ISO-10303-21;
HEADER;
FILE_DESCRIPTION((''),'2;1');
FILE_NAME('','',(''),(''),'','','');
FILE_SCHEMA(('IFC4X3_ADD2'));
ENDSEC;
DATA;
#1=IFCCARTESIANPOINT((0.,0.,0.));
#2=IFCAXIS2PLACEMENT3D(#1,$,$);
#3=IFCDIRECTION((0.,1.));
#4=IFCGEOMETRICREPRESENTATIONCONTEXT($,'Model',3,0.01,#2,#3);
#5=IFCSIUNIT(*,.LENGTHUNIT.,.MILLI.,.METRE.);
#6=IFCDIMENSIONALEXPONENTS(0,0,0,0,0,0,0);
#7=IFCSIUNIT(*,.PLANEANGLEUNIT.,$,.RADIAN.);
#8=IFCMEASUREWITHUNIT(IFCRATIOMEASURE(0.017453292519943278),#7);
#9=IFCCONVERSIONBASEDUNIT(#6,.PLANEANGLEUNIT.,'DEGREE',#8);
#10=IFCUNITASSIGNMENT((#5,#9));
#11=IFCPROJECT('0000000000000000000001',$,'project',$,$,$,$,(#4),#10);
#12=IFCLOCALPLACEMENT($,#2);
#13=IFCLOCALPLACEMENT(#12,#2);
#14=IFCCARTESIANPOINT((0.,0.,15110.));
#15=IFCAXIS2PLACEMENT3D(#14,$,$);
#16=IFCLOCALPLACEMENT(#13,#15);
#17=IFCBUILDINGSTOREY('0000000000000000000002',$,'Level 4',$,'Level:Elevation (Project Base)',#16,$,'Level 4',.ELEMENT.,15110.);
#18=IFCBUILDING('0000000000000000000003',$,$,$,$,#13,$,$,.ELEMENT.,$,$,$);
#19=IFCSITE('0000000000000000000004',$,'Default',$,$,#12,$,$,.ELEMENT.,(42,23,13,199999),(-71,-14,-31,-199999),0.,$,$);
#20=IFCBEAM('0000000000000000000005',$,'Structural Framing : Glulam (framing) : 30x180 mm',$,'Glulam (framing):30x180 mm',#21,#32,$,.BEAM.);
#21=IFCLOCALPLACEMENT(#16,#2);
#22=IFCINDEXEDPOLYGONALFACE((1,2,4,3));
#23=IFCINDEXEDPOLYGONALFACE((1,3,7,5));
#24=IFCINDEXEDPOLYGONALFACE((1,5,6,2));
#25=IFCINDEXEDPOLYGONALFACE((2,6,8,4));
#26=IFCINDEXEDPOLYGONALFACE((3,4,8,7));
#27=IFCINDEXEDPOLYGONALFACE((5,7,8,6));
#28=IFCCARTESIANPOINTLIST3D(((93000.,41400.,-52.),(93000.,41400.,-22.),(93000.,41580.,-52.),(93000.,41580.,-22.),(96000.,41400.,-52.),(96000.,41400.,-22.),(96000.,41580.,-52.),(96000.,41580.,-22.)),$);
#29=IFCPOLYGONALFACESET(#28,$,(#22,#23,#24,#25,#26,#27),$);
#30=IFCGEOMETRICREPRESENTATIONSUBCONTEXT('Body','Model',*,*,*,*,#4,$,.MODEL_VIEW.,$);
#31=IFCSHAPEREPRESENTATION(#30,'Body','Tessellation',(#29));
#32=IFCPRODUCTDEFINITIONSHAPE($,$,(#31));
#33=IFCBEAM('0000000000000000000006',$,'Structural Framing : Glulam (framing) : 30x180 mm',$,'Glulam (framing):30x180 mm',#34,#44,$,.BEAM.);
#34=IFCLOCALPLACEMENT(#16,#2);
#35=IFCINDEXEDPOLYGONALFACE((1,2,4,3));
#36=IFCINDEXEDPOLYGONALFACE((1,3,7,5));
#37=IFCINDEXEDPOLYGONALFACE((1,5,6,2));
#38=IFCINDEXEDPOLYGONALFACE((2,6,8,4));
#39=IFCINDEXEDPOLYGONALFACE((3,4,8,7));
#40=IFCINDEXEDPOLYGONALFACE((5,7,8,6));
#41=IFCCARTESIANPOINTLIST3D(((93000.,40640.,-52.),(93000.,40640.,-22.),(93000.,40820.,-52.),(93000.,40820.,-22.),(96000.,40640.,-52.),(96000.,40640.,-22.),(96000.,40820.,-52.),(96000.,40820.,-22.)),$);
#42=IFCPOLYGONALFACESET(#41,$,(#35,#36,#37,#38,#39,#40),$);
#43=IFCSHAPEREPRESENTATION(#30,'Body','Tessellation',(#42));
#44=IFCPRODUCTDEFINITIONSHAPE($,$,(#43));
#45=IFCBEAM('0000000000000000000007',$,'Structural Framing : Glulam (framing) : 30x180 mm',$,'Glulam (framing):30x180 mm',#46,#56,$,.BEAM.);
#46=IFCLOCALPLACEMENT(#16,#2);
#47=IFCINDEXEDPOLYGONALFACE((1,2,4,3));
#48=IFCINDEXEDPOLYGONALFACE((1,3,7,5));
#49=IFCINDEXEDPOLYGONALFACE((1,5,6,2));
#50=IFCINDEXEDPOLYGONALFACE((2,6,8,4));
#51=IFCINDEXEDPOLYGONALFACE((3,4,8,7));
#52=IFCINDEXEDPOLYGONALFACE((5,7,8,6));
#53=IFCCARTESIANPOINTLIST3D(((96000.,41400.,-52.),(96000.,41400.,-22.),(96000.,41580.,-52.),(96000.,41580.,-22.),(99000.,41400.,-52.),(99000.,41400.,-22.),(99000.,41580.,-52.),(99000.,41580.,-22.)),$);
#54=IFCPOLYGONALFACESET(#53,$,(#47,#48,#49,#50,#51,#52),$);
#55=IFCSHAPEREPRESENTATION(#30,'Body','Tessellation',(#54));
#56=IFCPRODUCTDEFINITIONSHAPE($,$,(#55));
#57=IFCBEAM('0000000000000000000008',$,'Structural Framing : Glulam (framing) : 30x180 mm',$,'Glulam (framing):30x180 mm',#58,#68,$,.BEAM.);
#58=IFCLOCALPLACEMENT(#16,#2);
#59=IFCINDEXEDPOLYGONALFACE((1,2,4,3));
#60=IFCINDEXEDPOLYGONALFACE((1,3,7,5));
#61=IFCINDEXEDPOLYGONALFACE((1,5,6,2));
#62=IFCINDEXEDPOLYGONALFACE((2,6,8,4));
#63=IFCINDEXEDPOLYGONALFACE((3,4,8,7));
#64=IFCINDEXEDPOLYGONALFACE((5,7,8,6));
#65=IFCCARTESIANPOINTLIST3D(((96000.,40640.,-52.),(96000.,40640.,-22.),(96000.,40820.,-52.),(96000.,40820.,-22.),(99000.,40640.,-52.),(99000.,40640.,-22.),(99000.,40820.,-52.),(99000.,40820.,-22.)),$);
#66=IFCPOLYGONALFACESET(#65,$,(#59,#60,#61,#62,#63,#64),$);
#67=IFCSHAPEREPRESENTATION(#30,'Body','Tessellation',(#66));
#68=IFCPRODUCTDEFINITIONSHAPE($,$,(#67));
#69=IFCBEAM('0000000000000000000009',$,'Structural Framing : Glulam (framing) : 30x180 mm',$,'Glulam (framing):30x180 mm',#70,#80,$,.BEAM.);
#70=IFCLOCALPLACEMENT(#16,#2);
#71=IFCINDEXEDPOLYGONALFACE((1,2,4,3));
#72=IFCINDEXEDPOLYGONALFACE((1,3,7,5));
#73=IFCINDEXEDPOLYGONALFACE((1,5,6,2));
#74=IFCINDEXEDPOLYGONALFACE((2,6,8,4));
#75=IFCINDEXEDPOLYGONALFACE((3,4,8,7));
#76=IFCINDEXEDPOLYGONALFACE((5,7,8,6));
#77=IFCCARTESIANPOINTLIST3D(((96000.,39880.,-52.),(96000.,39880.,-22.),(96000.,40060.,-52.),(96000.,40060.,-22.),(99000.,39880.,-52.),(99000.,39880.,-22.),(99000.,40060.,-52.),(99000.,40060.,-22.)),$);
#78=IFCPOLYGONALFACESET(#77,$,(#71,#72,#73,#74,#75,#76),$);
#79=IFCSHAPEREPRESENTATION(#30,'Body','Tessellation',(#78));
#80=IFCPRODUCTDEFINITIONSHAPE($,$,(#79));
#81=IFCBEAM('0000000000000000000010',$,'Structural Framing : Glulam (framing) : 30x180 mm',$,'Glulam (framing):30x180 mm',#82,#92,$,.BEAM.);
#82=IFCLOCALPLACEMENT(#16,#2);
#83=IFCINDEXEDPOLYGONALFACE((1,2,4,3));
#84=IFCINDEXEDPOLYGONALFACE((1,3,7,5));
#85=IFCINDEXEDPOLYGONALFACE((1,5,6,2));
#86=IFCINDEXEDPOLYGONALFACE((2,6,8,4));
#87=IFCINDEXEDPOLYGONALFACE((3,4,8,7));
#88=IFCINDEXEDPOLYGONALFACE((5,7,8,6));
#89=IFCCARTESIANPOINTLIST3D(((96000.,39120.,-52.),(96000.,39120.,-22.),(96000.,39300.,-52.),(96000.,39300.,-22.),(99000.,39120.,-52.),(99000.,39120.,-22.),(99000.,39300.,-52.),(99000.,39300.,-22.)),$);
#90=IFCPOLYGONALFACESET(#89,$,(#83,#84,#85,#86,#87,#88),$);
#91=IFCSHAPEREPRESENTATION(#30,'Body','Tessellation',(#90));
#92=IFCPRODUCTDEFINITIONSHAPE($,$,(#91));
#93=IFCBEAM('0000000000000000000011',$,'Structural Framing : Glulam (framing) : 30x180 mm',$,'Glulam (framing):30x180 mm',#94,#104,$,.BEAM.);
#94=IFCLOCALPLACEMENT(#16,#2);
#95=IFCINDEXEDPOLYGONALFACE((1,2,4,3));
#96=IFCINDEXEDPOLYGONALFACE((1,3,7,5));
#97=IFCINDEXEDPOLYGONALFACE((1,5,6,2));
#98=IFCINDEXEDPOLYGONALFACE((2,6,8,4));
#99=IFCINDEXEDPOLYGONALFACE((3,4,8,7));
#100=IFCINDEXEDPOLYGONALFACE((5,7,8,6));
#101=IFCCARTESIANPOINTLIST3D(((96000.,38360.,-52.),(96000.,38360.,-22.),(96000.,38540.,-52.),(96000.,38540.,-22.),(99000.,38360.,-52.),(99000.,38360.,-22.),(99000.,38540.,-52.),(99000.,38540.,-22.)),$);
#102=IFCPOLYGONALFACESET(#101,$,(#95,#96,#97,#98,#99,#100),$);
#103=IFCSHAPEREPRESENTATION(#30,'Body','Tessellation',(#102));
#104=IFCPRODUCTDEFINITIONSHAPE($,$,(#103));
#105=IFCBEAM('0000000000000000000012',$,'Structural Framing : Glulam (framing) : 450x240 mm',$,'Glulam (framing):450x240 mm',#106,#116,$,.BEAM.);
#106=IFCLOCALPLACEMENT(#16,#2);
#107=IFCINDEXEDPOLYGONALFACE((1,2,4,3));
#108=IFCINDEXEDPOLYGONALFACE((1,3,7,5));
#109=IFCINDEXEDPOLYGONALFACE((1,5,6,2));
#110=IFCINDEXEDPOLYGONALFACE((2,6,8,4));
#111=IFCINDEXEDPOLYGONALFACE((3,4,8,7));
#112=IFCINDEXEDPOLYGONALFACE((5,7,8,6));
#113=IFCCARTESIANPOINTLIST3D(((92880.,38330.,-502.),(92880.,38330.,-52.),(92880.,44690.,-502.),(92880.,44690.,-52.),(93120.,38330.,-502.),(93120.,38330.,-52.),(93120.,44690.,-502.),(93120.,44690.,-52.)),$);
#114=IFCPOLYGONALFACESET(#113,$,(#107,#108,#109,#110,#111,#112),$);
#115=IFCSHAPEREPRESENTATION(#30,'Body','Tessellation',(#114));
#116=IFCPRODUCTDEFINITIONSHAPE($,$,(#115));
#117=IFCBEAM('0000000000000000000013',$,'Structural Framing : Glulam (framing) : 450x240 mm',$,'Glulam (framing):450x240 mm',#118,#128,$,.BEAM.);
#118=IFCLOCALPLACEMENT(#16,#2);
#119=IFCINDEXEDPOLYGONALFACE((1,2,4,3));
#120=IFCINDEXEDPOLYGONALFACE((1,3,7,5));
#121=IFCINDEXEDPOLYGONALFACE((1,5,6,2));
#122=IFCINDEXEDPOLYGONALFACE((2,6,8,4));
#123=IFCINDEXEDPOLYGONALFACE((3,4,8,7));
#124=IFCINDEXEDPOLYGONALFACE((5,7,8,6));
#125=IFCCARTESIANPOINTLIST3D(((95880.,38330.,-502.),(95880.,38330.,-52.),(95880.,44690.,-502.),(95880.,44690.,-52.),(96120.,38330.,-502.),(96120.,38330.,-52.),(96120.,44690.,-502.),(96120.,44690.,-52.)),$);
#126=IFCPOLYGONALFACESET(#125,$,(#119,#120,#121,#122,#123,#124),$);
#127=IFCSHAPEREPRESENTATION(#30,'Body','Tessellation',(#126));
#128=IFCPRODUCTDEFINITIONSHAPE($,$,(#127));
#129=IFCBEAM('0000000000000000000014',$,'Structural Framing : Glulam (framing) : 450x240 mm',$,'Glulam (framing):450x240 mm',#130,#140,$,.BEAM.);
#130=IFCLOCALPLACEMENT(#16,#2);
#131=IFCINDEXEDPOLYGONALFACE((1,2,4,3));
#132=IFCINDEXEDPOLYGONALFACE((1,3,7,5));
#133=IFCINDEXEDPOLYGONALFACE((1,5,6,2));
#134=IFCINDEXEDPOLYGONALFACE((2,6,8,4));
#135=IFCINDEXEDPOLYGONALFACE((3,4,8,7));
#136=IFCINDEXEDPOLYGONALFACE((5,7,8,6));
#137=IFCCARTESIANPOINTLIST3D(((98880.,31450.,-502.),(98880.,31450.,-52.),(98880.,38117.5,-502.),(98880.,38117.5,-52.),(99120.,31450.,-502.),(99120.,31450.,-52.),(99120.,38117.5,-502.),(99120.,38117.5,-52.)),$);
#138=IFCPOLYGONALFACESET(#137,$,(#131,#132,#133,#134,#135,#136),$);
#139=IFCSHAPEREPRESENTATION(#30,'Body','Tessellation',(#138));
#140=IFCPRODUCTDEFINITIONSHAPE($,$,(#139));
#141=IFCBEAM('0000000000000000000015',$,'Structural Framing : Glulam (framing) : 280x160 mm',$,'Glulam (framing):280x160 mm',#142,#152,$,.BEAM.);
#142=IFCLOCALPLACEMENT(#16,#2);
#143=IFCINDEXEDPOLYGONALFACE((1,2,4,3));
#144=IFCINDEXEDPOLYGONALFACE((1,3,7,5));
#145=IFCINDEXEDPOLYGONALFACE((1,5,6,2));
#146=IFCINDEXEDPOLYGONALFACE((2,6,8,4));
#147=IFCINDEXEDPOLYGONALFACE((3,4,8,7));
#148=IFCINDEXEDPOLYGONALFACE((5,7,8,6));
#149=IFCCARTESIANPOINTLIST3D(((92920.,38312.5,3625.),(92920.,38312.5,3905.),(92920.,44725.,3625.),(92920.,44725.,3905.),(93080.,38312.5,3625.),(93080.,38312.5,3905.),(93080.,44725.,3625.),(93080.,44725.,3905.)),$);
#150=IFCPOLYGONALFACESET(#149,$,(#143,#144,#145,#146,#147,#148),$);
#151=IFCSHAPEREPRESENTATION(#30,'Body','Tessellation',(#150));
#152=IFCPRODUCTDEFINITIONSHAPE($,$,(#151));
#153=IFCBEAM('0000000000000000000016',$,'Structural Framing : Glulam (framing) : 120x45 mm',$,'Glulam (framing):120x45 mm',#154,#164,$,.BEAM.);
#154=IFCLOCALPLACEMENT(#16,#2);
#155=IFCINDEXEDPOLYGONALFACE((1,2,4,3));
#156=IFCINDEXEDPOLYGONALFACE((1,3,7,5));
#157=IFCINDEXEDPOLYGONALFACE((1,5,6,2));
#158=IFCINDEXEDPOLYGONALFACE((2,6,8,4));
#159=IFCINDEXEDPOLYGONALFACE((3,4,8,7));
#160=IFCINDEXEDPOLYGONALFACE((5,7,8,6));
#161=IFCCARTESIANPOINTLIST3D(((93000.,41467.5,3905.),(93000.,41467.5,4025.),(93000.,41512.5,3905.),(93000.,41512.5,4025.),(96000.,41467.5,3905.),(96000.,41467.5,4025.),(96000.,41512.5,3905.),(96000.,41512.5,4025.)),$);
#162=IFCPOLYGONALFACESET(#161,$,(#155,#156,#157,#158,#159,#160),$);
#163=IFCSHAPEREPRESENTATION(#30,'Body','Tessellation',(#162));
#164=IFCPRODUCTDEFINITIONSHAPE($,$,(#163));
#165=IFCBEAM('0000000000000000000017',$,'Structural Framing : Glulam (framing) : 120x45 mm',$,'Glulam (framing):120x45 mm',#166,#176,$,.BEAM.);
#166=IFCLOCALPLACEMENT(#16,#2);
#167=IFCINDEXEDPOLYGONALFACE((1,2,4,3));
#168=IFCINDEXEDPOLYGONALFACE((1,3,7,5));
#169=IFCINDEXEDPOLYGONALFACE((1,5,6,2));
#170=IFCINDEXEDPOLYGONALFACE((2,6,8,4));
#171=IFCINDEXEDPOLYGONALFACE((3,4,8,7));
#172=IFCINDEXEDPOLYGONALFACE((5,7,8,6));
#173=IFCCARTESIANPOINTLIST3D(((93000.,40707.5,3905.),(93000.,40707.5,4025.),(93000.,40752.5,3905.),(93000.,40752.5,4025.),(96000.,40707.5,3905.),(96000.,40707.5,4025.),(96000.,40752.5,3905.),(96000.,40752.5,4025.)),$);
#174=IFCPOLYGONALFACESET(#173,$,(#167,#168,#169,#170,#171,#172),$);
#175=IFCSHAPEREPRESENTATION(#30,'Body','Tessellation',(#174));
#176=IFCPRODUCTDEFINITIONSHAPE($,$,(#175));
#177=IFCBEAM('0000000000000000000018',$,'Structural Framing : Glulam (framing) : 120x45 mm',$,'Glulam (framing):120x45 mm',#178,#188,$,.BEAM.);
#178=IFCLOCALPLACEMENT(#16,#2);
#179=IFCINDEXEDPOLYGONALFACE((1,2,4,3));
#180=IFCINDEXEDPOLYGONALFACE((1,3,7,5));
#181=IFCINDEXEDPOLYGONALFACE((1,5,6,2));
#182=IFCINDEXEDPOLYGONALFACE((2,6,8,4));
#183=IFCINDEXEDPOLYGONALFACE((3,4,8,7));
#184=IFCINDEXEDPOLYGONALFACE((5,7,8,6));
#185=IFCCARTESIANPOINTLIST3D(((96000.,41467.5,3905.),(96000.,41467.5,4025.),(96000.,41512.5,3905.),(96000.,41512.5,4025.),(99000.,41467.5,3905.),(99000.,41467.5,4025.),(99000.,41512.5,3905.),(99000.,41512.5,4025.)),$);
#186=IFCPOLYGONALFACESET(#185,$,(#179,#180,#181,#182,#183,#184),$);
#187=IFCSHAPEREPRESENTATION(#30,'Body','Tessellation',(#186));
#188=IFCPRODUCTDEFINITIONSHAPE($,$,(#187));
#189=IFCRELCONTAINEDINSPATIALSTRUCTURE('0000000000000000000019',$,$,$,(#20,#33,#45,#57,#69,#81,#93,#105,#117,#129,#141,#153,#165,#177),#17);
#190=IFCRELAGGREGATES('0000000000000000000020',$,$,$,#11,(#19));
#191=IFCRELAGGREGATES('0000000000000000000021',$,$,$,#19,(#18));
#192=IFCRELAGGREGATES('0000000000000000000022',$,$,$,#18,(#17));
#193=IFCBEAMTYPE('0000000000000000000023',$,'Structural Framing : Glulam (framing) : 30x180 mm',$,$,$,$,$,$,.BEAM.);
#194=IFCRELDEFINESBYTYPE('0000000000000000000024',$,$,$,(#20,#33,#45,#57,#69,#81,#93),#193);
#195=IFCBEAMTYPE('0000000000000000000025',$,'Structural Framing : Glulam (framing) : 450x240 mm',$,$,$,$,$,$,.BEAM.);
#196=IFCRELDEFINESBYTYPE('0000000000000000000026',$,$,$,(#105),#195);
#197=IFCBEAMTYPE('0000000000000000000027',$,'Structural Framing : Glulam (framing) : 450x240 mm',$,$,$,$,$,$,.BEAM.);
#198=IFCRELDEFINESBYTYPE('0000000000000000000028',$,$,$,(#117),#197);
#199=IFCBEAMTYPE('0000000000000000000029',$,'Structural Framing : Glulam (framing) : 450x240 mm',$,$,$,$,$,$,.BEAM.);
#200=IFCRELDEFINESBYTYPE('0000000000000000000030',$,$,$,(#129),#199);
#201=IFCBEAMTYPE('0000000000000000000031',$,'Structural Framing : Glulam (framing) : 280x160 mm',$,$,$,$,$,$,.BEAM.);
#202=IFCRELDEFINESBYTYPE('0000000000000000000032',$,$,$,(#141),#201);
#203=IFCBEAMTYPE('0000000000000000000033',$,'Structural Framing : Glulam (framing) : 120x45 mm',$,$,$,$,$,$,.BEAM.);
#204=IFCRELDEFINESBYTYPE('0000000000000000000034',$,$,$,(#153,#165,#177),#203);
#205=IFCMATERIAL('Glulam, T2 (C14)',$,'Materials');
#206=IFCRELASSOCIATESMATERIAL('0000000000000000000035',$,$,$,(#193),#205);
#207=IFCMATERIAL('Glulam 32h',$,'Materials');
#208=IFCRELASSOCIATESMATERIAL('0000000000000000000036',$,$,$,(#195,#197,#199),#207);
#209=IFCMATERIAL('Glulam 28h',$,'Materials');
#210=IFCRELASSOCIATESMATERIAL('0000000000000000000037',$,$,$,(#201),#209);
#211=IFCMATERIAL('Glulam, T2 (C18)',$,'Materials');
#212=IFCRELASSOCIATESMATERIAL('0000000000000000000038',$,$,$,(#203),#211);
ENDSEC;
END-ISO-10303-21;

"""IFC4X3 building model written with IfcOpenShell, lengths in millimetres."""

from ifc_helpers import new_model, entity, si_unit, converted_unit, direction, frame, origin, origin_2d_with_axis, place, context, subcontext, project, spatial, rectangle, extrude, source, transform, mapped, material, material_profile, profile_set, type_object, type_shapes, element, save


model = new_model("IFC4X3")

# Units and contexts
model_context = context("Model", 3, precision=0.01, world=origin(), true_north=direction((0.0, 1.0)))
body_context = subcontext(model_context, "Body", "Model", "MODEL_VIEW")
ifc_project = project(units=[si_unit("LENGTHUNIT", "METRE", prefix="MILLI"), converted_unit("PLANEANGLEUNIT", "DEGREE", entity("IfcRatioMeasure", 0.017453292519943278), si_unit("PLANEANGLEUNIT", "RADIAN"), dimensions=[0, 0, 0, 0, 0, 0, 0])], contexts=[model_context])

# Site, building, storey
site_placement = place(None, origin())
site = spatial("IfcSite", under=ifc_project, at=site_placement, Name="Default", CompositionType="ELEMENT", RefLatitude=(42, 23, 13, 199999), RefLongitude=(-71, -14, -31, -199999), RefElevation=0.0)
building_placement = place(site_placement, origin())
building = spatial("IfcBuilding", under=site, at=building_placement, CompositionType="ELEMENT")
storey_placement = place(building_placement, frame((0.0, 0.0, 15110.0)))
storey = spatial("IfcBuildingStorey", under=building, at=storey_placement, Name="Level 4", ObjectType="Level:Elevation (Project Base)", LongName="Level 4", CompositionType="ELEMENT", Elevation=15110.0)

# Beams
ifc_material_1 = material(Name="Glulam, T2 (C14)", Category="Materials")
ifc_material_profile_1 = material_profile(ifc_material_1, rectangle(XDim=30.0, YDim=180.0, at=origin_2d_with_axis()), Name="30x180 mm")
ifc_profile_set_1 = profile_set([ifc_material_profile_1], Name="30x180 mm")
beam_type_1 = type_object("IfcBeamType", Name="Structural Framing : Glulam (framing) : 30x180 mm", PredefinedType="BEAM", material=ifc_profile_set_1)
shared_shape_1 = source(origin(), body_context, "Body", "SweptSolid", [
    extrude(rectangle(XDim=30.0, YDim=180.0, at=origin_2d_with_axis()), frame((500.0, 0.0, 0.0), z_axis=(1.0, 0.0, 0.0), x_axis=(0.0, 0.0, -1.0)), (0.0, 0.0, 1.0), 3000.0),
])
type_shapes(beam_type_1, [shared_shape_1])
for number, where, name in (
    (1, (92500.0, 41490.0, -37.0), "Structural Framing : Glulam (framing) : 30x180 mm"),
    (2, (92500.0, 40730.0, -37.0), "Structural Framing : Glulam (framing) : 30x180 mm"),
    (3, (95500.0, 41490.0, -37.0), "Structural Framing : Glulam (framing) : 30x180 mm"),
    (4, (95500.0, 40730.0, -37.0), "Structural Framing : Glulam (framing) : 30x180 mm"),
    (5, (95500.0, 39970.0, -37.0), "Structural Framing : Glulam (framing) : 30x180 mm"),
    (6, (95500.0, 39210.0, -37.0), "Structural Framing : Glulam (framing) : 30x180 mm"),
    (7, (95500.0, 38450.0, -37.0), "Structural Framing : Glulam (framing) : 30x180 mm"),
):
    element("IfcBeam", number, at=place(storey_placement, frame(where)), inside=storey, type_object=beam_type_1, Name=name, ObjectType="Glulam (framing):30x180 mm", PredefinedType="BEAM", context=body_context, shape_type="MappedRepresentation", body=[
        mapped(shared_shape_1, transform((0.0, 0.0, 0.0), scale=1.0)),
    ])
ifc_material_2 = material(Name="Glulam 32h", Category="Materials")
ifc_material_profile_2 = material_profile(ifc_material_2, rectangle(XDim=450.0, YDim=240.0, at=origin_2d_with_axis()), Name="450x240 mm")
ifc_profile_set_2 = profile_set([ifc_material_profile_2], Name="450x240 mm")
beam_type_2 = type_object("IfcBeamType", Name="Structural Framing : Glulam (framing) : 450x240 mm", PredefinedType="BEAM", material=ifc_profile_set_2)
shared_shape_2 = source(origin(), body_context, "Body", "SweptSolid", [
    extrude(rectangle(XDim=450.0, YDim=240.0, at=origin_2d_with_axis()), frame((-3256.2, 0.0, 0.0), z_axis=(1.0, 0.0, 0.0), x_axis=(0.0, 0.0, -1.0)), (0.0, 0.0, 1.0), 6360.0),
])
type_shapes(beam_type_2, [shared_shape_2])
beam_1_placement = place(storey_placement, frame((93000.0, 41433.7, -277.0), z_axis=(0.0, 0.0, 1.0), x_axis=(0.0, -1.0, 0.0)))
element("IfcBeam", 8, at=beam_1_placement, inside=storey, type_object=beam_type_2, Name="Structural Framing : Glulam (framing) : 450x240 mm", ObjectType="Glulam (framing):450x240 mm", PredefinedType="BEAM", context=body_context, shape_type="MappedRepresentation", body=[
    mapped(shared_shape_2, transform((0.0, 0.0, 0.0), scale=1.0)),
])
beam_type_3 = type_object("IfcBeamType", Name="Structural Framing : Glulam (framing) : 450x240 mm", PredefinedType="BEAM", material=ifc_profile_set_2)
shared_shape_3 = source(origin(), body_context, "Body", "SweptSolid", [
    extrude(rectangle(XDim=450.0, YDim=240.0, at=origin_2d_with_axis()), frame((-2950.0, 0.0, 0.0), z_axis=(1.0, 0.0, 0.0), x_axis=(0.0, 0.0, -1.0)), (0.0, 0.0, 1.0), 6360.0),
])
type_shapes(beam_type_3, [shared_shape_3])
beam_2_placement = place(storey_placement, frame((96000.0, 41740.0, -277.0), z_axis=(0.0, 0.0, 1.0), x_axis=(0.0, -1.0, 0.0)))
element("IfcBeam", 9, at=beam_2_placement, inside=storey, type_object=beam_type_3, Name="Structural Framing : Glulam (framing) : 450x240 mm", ObjectType="Glulam (framing):450x240 mm", PredefinedType="BEAM", context=body_context, shape_type="MappedRepresentation", body=[
    mapped(shared_shape_3, transform((0.0, 0.0, 0.0), scale=1.0)),
])
beam_type_4 = type_object("IfcBeamType", Name="Structural Framing : Glulam (framing) : 450x240 mm", PredefinedType="BEAM", material=ifc_profile_set_2)
shared_shape_4 = source(origin(), body_context, "Body", "SweptSolid", [
    extrude(rectangle(XDim=450.0, YDim=240.0, at=origin_2d_with_axis()), frame((2866.2, 0.0, 0.0), z_axis=(1.0, 0.0, 0.0), x_axis=(0.0, 0.0, -1.0)), (0.0, 0.0, 1.0), 6667.5),
])
type_shapes(beam_type_4, [shared_shape_4])
beam_3_placement = place(storey_placement, frame((99000.0, 40983.7, -277.0), z_axis=(0.0, 0.0, 1.0), x_axis=(0.0, -1.0, 0.0)))
element("IfcBeam", 10, at=beam_3_placement, inside=storey, type_object=beam_type_4, Name="Structural Framing : Glulam (framing) : 450x240 mm", ObjectType="Glulam (framing):450x240 mm", PredefinedType="BEAM", context=body_context, shape_type="MappedRepresentation", body=[
    mapped(shared_shape_4, transform((0.0, 0.0, 0.0), scale=1.0)),
])
ifc_material_3 = material(Name="Glulam 28h", Category="Materials")
ifc_material_profile_3 = material_profile(ifc_material_3, rectangle(XDim=280.0, YDim=160.0, at=origin_2d_with_axis()), Name="280x160 mm")
ifc_profile_set_3 = profile_set([ifc_material_profile_3], Name="280x160 mm")
beam_type_5 = type_object("IfcBeamType", Name="Structural Framing : Glulam (framing) : 280x160 mm", PredefinedType="BEAM", material=ifc_profile_set_3)
shared_shape_5 = source(origin(), body_context, "Body", "SweptSolid", [
    extrude(rectangle(XDim=280.0, YDim=160.0, at=origin_2d_with_axis()), frame((-2982.5, 0.0, 0.0), z_axis=(1.0, 0.0, 0.0), x_axis=(0.0, 0.0, -1.0)), (0.0, 0.0, 1.0), 6412.5),
])
type_shapes(beam_type_5, [shared_shape_5])
beam_4_placement = place(storey_placement, frame((93000.0, 41742.5, 3765.0), z_axis=(0.0, 0.0, 1.0), x_axis=(0.0, -1.0, 0.0)))
element("IfcBeam", 11, at=beam_4_placement, inside=storey, type_object=beam_type_5, Name="Structural Framing : Glulam (framing) : 280x160 mm", ObjectType="Glulam (framing):280x160 mm", PredefinedType="BEAM", context=body_context, shape_type="MappedRepresentation", body=[
    mapped(shared_shape_5, transform((0.0, 0.0, 0.0), scale=1.0)),
])
ifc_material_4 = material(Name="Glulam, T2 (C18)", Category="Materials")
ifc_material_profile_4 = material_profile(ifc_material_4, rectangle(XDim=120.0, YDim=45.0, at=origin_2d_with_axis()), Name="120x45 mm")
ifc_profile_set_4 = profile_set([ifc_material_profile_4], Name="120x45 mm")
beam_type_6 = type_object("IfcBeamType", Name="Structural Framing : Glulam (framing) : 120x45 mm", PredefinedType="BEAM", material=ifc_profile_set_4)
shared_shape_6 = source(origin(), body_context, "Body", "SweptSolid", [
    extrude(rectangle(XDim=120.0, YDim=45.0, at=origin_2d_with_axis()), frame((500.0, 0.0, 0.0), z_axis=(1.0, 0.0, 0.0), x_axis=(0.0, 0.0, -1.0)), (0.0, 0.0, 1.0), 3000.0),
])
type_shapes(beam_type_6, [shared_shape_6])
for number, where, name in (
    (12, (92500.0, 41490.0, 3965.0), "Structural Framing : Glulam (framing) : 120x45 mm"),
    (13, (92500.0, 40730.0, 3965.0), "Structural Framing : Glulam (framing) : 120x45 mm"),
    (14, (95500.0, 41490.0, 3965.0), "Structural Framing : Glulam (framing) : 120x45 mm"),
):
    element("IfcBeam", number, at=place(storey_placement, frame(where)), inside=storey, type_object=beam_type_6, Name=name, ObjectType="Glulam (framing):120x45 mm", PredefinedType="BEAM", context=body_context, shape_type="MappedRepresentation", body=[
        mapped(shared_shape_6, transform((0.0, 0.0, 0.0), scale=1.0)),
    ])

save(model, "model.ifc")
